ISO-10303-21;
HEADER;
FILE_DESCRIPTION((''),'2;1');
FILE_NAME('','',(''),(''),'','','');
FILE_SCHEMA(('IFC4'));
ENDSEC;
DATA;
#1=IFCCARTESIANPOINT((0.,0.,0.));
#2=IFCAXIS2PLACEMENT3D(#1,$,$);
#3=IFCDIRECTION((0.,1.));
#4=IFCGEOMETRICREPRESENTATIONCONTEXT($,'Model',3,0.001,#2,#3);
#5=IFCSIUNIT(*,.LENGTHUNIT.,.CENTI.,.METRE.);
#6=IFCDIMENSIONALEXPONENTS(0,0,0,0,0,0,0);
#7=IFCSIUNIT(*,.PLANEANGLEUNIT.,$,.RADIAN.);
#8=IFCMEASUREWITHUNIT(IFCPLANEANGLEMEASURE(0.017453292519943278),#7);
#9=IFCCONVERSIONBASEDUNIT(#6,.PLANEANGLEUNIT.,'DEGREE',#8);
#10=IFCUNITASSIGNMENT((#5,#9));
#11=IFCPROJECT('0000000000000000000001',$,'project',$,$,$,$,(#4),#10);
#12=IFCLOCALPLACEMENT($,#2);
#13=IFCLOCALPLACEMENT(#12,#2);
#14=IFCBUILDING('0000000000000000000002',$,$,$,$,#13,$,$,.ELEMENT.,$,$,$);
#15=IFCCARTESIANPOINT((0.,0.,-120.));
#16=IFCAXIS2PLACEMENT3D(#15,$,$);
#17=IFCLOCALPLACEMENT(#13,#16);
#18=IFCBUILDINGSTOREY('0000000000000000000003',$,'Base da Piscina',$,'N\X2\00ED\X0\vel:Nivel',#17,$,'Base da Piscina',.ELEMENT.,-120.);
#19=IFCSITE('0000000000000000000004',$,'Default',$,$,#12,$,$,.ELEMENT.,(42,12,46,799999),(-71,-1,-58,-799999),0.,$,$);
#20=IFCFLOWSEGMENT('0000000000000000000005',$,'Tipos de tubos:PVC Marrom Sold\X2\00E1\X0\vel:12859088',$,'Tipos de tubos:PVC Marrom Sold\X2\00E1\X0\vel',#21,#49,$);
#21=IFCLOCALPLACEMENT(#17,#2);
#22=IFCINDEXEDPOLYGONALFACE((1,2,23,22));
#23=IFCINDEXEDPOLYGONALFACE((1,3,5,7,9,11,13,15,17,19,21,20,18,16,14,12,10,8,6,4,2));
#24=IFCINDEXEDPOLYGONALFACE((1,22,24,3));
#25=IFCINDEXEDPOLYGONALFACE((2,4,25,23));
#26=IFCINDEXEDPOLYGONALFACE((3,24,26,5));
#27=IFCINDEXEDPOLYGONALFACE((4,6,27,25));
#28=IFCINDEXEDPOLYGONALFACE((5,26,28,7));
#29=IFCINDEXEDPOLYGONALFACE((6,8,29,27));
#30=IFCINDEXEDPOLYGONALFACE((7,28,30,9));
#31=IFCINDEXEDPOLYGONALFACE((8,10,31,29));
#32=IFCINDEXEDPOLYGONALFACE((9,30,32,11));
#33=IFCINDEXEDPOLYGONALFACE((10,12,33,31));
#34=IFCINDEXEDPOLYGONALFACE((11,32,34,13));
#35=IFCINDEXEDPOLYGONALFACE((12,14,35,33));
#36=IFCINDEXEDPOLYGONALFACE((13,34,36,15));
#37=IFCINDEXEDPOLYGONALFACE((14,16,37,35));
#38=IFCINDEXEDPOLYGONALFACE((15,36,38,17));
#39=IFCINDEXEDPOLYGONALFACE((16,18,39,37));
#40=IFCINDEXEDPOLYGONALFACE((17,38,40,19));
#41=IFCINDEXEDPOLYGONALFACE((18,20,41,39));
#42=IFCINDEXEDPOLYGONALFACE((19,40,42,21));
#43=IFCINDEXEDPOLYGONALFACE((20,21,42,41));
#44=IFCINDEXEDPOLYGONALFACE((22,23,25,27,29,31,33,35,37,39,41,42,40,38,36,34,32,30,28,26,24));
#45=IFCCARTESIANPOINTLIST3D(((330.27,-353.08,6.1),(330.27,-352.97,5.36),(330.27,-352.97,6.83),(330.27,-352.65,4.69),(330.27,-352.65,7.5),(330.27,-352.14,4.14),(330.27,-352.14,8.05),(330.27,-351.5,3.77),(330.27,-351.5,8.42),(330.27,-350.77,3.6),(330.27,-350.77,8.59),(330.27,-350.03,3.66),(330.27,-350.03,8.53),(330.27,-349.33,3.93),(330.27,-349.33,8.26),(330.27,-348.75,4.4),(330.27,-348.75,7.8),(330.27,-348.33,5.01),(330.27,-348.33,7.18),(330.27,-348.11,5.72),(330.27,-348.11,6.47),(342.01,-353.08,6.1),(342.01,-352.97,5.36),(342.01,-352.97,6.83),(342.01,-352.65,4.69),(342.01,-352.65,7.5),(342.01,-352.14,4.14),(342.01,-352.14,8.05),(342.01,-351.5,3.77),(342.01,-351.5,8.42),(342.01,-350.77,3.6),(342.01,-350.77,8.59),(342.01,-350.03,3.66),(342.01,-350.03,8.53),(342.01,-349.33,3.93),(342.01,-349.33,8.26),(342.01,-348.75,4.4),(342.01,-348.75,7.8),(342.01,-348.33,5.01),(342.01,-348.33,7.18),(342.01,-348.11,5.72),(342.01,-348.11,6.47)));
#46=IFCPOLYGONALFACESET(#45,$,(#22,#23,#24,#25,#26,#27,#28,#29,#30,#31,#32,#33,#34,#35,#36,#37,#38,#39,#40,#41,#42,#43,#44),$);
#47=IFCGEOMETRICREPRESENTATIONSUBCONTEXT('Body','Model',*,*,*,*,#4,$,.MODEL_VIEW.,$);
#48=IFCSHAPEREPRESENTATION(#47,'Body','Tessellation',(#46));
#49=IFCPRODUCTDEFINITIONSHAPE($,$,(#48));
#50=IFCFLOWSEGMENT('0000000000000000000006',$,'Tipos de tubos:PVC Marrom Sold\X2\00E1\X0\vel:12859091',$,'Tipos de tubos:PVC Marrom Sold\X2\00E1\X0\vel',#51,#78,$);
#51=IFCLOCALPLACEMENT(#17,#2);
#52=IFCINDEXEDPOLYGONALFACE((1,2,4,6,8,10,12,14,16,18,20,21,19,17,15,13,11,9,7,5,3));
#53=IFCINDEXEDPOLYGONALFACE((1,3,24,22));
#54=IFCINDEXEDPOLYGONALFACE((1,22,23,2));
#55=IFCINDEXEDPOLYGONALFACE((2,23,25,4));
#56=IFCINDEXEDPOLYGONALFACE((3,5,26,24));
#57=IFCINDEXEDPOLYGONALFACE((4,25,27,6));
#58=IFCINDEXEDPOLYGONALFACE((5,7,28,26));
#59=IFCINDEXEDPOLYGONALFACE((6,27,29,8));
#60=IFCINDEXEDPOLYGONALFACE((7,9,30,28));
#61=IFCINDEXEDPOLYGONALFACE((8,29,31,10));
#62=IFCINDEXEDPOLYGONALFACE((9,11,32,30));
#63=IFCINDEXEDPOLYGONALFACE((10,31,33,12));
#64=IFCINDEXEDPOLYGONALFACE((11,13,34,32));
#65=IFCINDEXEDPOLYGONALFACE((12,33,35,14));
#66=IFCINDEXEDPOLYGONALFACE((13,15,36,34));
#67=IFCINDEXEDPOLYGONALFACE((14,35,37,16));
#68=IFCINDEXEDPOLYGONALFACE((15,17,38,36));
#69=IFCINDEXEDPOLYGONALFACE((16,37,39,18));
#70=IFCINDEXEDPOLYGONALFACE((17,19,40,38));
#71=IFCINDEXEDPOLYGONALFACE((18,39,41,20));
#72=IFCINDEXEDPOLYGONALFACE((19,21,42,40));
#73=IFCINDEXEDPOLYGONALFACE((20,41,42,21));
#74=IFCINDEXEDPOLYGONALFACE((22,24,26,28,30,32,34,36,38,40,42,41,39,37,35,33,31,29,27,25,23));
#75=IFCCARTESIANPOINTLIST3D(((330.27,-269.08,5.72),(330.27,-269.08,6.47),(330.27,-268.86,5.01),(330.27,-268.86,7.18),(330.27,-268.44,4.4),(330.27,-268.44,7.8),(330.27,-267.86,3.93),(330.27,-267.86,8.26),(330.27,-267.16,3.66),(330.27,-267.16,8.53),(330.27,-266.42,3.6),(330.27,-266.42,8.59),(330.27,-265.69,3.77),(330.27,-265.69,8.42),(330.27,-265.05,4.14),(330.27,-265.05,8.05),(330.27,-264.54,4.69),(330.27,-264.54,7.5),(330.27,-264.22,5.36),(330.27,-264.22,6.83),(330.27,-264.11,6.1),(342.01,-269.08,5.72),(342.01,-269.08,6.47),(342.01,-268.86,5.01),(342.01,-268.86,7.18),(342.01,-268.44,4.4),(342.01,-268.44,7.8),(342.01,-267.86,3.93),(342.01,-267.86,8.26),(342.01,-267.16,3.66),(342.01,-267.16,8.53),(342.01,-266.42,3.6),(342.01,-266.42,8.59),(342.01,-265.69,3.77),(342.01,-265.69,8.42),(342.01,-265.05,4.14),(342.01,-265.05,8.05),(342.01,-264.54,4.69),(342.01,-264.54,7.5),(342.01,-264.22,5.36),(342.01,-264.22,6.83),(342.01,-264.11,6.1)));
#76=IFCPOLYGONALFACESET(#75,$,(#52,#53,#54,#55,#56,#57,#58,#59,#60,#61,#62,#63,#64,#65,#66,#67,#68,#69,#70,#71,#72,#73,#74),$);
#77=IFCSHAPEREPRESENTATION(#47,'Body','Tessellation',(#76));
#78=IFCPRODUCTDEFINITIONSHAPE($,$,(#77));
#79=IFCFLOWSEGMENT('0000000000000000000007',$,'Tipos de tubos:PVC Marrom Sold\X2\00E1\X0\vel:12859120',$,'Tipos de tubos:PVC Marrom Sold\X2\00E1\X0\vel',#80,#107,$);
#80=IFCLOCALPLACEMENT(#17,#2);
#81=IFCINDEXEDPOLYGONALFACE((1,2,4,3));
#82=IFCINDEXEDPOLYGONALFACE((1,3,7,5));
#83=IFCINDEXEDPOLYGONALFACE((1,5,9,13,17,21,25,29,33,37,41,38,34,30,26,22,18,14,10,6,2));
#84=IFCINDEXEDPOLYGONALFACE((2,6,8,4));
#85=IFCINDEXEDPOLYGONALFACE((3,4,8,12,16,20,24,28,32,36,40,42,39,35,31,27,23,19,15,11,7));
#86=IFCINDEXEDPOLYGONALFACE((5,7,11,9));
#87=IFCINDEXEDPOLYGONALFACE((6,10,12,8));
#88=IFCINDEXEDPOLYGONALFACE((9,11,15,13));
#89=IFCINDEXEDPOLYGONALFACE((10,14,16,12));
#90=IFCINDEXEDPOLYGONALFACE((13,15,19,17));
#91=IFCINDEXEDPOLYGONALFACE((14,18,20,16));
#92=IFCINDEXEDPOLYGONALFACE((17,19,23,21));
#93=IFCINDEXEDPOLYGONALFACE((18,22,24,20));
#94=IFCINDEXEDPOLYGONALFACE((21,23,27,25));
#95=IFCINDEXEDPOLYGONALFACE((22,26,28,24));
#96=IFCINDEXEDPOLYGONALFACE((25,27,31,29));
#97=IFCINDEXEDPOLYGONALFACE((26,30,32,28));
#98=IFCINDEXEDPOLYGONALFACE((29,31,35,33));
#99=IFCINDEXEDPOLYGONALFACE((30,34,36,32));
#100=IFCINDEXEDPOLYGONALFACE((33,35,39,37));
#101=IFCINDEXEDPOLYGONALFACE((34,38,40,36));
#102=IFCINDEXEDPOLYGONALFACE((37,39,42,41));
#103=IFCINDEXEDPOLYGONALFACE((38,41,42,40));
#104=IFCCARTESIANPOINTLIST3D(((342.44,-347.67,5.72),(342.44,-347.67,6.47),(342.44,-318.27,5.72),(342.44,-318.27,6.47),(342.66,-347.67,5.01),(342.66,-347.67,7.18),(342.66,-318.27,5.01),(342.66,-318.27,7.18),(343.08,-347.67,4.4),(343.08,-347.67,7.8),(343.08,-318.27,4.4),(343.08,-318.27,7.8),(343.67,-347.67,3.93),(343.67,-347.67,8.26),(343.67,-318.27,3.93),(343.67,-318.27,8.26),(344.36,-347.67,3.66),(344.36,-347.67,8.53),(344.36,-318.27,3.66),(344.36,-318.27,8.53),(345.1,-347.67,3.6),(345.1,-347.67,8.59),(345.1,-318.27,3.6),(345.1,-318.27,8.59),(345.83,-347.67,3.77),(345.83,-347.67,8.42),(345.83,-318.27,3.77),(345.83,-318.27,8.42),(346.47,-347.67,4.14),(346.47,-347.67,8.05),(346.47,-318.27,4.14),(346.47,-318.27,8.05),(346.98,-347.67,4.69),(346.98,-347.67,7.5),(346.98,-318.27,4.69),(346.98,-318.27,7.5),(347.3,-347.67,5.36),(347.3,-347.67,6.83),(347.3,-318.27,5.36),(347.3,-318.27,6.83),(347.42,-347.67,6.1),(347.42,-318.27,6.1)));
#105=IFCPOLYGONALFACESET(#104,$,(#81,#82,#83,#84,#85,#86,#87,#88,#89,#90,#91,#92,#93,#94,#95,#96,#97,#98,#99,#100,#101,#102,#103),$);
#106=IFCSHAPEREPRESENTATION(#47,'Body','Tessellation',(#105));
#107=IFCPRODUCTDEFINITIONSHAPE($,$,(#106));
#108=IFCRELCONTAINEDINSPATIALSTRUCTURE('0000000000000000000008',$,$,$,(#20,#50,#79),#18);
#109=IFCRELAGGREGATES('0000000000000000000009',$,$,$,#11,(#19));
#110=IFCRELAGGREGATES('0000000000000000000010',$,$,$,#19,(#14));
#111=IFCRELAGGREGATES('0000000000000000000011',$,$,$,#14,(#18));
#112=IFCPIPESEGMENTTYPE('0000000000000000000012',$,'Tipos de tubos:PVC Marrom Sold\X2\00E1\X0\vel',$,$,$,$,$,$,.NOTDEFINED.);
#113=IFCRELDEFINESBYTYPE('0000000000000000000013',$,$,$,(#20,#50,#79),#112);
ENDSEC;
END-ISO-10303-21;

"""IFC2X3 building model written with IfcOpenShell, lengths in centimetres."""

from ifc_helpers import new_model, entity, si_unit, converted_unit, direction, frame, origin, origin_2d_with_axis, place, context, subcontext, project, spatial, circle, extrude, type_object, element, save


model = new_model("IFC2X3")

# Units and contexts
model_context = context("Model", 3, precision=0.001, world=origin(), true_north=direction((0.0, 1.0)))
body_context = subcontext(model_context, "Body", "Model", "MODEL_VIEW")
ifc_project = project(units=[si_unit("LENGTHUNIT", "METRE", prefix="CENTI"), converted_unit("PLANEANGLEUNIT", "DEGREE", entity("IfcPlaneAngleMeasure", 0.017453292519943278), si_unit("PLANEANGLEUNIT", "RADIAN"), dimensions=[0, 0, 0, 0, 0, 0, 0])], contexts=[model_context])

# Site, building, storey
site_placement = place(None, origin())
site = spatial("IfcSite", under=ifc_project, at=site_placement, Name="Default", CompositionType="ELEMENT", RefLatitude=(42, 12, 46, 799999), RefLongitude=(-71, -1, -58, -799999), RefElevation=0.0)
building_placement = place(site_placement, origin())
building = spatial("IfcBuilding", under=site, at=building_placement, CompositionType="ELEMENT")
storey_placement = place(building_placement, frame((0.0, 0.0, -120.0)))
storey = spatial("IfcBuildingStorey", under=building, at=storey_placement, Name="Base da Piscina", ObjectType="Nível:Nivel", LongName="Base da Piscina", CompositionType="ELEMENT", Elevation=-120.0)

# Flow segments
pipe_segment_type = type_object("IfcPipeSegmentType", Name="Tipos de tubos:PVC Marrom Soldável", PredefinedType="NOTDEFINED")
flow_segment_1_placement = place(storey_placement, origin())
element("IfcFlowSegment", 1, at=flow_segment_1_placement, inside=storey, type_object=pipe_segment_type, Name="Tipos de tubos:PVC Marrom Soldável:12859088", ObjectType="Tipos de tubos:PVC Marrom Soldável", context=body_context, shape_type="SweptSolid", body=[
    extrude(circle(Radius=2.5, at=origin_2d_with_axis()), frame((330.27, -350.58, 6.1), z_axis=(1.0, 0.0, 0.0), x_axis=(0.0, -1.0, 0.0)), (0.0, 0.0, 1.0), 11.74),
])
flow_segment_2_placement = place(storey_placement, origin())
element("IfcFlowSegment", 2, at=flow_segment_2_placement, inside=storey, type_object=pipe_segment_type, Name="Tipos de tubos:PVC Marrom Soldável:12859091", ObjectType="Tipos de tubos:PVC Marrom Soldável", context=body_context, shape_type="SweptSolid", body=[
    extrude(circle(Radius=2.5, at=origin_2d_with_axis()), frame((330.27, -266.61, 6.1), z_axis=(1.0, 0.0, 0.0), x_axis=(0.0, 1.0, 0.0)), (0.0, 0.0, 1.0), 11.74),
])
flow_segment_3_placement = place(storey_placement, origin())
element("IfcFlowSegment", 3, at=flow_segment_3_placement, inside=storey, type_object=pipe_segment_type, Name="Tipos de tubos:PVC Marrom Soldável:12859120", ObjectType="Tipos de tubos:PVC Marrom Soldável", context=body_context, shape_type="SweptSolid", body=[
    extrude(circle(Radius=2.5, at=origin_2d_with_axis()), frame((344.92, -347.67, 6.1), z_axis=(0.0, 1.0, 0.0), x_axis=(1.0, 0.0, 0.0)), (0.0, 0.0, 1.0), 29.4),
])

save(model, "model.ifc")
